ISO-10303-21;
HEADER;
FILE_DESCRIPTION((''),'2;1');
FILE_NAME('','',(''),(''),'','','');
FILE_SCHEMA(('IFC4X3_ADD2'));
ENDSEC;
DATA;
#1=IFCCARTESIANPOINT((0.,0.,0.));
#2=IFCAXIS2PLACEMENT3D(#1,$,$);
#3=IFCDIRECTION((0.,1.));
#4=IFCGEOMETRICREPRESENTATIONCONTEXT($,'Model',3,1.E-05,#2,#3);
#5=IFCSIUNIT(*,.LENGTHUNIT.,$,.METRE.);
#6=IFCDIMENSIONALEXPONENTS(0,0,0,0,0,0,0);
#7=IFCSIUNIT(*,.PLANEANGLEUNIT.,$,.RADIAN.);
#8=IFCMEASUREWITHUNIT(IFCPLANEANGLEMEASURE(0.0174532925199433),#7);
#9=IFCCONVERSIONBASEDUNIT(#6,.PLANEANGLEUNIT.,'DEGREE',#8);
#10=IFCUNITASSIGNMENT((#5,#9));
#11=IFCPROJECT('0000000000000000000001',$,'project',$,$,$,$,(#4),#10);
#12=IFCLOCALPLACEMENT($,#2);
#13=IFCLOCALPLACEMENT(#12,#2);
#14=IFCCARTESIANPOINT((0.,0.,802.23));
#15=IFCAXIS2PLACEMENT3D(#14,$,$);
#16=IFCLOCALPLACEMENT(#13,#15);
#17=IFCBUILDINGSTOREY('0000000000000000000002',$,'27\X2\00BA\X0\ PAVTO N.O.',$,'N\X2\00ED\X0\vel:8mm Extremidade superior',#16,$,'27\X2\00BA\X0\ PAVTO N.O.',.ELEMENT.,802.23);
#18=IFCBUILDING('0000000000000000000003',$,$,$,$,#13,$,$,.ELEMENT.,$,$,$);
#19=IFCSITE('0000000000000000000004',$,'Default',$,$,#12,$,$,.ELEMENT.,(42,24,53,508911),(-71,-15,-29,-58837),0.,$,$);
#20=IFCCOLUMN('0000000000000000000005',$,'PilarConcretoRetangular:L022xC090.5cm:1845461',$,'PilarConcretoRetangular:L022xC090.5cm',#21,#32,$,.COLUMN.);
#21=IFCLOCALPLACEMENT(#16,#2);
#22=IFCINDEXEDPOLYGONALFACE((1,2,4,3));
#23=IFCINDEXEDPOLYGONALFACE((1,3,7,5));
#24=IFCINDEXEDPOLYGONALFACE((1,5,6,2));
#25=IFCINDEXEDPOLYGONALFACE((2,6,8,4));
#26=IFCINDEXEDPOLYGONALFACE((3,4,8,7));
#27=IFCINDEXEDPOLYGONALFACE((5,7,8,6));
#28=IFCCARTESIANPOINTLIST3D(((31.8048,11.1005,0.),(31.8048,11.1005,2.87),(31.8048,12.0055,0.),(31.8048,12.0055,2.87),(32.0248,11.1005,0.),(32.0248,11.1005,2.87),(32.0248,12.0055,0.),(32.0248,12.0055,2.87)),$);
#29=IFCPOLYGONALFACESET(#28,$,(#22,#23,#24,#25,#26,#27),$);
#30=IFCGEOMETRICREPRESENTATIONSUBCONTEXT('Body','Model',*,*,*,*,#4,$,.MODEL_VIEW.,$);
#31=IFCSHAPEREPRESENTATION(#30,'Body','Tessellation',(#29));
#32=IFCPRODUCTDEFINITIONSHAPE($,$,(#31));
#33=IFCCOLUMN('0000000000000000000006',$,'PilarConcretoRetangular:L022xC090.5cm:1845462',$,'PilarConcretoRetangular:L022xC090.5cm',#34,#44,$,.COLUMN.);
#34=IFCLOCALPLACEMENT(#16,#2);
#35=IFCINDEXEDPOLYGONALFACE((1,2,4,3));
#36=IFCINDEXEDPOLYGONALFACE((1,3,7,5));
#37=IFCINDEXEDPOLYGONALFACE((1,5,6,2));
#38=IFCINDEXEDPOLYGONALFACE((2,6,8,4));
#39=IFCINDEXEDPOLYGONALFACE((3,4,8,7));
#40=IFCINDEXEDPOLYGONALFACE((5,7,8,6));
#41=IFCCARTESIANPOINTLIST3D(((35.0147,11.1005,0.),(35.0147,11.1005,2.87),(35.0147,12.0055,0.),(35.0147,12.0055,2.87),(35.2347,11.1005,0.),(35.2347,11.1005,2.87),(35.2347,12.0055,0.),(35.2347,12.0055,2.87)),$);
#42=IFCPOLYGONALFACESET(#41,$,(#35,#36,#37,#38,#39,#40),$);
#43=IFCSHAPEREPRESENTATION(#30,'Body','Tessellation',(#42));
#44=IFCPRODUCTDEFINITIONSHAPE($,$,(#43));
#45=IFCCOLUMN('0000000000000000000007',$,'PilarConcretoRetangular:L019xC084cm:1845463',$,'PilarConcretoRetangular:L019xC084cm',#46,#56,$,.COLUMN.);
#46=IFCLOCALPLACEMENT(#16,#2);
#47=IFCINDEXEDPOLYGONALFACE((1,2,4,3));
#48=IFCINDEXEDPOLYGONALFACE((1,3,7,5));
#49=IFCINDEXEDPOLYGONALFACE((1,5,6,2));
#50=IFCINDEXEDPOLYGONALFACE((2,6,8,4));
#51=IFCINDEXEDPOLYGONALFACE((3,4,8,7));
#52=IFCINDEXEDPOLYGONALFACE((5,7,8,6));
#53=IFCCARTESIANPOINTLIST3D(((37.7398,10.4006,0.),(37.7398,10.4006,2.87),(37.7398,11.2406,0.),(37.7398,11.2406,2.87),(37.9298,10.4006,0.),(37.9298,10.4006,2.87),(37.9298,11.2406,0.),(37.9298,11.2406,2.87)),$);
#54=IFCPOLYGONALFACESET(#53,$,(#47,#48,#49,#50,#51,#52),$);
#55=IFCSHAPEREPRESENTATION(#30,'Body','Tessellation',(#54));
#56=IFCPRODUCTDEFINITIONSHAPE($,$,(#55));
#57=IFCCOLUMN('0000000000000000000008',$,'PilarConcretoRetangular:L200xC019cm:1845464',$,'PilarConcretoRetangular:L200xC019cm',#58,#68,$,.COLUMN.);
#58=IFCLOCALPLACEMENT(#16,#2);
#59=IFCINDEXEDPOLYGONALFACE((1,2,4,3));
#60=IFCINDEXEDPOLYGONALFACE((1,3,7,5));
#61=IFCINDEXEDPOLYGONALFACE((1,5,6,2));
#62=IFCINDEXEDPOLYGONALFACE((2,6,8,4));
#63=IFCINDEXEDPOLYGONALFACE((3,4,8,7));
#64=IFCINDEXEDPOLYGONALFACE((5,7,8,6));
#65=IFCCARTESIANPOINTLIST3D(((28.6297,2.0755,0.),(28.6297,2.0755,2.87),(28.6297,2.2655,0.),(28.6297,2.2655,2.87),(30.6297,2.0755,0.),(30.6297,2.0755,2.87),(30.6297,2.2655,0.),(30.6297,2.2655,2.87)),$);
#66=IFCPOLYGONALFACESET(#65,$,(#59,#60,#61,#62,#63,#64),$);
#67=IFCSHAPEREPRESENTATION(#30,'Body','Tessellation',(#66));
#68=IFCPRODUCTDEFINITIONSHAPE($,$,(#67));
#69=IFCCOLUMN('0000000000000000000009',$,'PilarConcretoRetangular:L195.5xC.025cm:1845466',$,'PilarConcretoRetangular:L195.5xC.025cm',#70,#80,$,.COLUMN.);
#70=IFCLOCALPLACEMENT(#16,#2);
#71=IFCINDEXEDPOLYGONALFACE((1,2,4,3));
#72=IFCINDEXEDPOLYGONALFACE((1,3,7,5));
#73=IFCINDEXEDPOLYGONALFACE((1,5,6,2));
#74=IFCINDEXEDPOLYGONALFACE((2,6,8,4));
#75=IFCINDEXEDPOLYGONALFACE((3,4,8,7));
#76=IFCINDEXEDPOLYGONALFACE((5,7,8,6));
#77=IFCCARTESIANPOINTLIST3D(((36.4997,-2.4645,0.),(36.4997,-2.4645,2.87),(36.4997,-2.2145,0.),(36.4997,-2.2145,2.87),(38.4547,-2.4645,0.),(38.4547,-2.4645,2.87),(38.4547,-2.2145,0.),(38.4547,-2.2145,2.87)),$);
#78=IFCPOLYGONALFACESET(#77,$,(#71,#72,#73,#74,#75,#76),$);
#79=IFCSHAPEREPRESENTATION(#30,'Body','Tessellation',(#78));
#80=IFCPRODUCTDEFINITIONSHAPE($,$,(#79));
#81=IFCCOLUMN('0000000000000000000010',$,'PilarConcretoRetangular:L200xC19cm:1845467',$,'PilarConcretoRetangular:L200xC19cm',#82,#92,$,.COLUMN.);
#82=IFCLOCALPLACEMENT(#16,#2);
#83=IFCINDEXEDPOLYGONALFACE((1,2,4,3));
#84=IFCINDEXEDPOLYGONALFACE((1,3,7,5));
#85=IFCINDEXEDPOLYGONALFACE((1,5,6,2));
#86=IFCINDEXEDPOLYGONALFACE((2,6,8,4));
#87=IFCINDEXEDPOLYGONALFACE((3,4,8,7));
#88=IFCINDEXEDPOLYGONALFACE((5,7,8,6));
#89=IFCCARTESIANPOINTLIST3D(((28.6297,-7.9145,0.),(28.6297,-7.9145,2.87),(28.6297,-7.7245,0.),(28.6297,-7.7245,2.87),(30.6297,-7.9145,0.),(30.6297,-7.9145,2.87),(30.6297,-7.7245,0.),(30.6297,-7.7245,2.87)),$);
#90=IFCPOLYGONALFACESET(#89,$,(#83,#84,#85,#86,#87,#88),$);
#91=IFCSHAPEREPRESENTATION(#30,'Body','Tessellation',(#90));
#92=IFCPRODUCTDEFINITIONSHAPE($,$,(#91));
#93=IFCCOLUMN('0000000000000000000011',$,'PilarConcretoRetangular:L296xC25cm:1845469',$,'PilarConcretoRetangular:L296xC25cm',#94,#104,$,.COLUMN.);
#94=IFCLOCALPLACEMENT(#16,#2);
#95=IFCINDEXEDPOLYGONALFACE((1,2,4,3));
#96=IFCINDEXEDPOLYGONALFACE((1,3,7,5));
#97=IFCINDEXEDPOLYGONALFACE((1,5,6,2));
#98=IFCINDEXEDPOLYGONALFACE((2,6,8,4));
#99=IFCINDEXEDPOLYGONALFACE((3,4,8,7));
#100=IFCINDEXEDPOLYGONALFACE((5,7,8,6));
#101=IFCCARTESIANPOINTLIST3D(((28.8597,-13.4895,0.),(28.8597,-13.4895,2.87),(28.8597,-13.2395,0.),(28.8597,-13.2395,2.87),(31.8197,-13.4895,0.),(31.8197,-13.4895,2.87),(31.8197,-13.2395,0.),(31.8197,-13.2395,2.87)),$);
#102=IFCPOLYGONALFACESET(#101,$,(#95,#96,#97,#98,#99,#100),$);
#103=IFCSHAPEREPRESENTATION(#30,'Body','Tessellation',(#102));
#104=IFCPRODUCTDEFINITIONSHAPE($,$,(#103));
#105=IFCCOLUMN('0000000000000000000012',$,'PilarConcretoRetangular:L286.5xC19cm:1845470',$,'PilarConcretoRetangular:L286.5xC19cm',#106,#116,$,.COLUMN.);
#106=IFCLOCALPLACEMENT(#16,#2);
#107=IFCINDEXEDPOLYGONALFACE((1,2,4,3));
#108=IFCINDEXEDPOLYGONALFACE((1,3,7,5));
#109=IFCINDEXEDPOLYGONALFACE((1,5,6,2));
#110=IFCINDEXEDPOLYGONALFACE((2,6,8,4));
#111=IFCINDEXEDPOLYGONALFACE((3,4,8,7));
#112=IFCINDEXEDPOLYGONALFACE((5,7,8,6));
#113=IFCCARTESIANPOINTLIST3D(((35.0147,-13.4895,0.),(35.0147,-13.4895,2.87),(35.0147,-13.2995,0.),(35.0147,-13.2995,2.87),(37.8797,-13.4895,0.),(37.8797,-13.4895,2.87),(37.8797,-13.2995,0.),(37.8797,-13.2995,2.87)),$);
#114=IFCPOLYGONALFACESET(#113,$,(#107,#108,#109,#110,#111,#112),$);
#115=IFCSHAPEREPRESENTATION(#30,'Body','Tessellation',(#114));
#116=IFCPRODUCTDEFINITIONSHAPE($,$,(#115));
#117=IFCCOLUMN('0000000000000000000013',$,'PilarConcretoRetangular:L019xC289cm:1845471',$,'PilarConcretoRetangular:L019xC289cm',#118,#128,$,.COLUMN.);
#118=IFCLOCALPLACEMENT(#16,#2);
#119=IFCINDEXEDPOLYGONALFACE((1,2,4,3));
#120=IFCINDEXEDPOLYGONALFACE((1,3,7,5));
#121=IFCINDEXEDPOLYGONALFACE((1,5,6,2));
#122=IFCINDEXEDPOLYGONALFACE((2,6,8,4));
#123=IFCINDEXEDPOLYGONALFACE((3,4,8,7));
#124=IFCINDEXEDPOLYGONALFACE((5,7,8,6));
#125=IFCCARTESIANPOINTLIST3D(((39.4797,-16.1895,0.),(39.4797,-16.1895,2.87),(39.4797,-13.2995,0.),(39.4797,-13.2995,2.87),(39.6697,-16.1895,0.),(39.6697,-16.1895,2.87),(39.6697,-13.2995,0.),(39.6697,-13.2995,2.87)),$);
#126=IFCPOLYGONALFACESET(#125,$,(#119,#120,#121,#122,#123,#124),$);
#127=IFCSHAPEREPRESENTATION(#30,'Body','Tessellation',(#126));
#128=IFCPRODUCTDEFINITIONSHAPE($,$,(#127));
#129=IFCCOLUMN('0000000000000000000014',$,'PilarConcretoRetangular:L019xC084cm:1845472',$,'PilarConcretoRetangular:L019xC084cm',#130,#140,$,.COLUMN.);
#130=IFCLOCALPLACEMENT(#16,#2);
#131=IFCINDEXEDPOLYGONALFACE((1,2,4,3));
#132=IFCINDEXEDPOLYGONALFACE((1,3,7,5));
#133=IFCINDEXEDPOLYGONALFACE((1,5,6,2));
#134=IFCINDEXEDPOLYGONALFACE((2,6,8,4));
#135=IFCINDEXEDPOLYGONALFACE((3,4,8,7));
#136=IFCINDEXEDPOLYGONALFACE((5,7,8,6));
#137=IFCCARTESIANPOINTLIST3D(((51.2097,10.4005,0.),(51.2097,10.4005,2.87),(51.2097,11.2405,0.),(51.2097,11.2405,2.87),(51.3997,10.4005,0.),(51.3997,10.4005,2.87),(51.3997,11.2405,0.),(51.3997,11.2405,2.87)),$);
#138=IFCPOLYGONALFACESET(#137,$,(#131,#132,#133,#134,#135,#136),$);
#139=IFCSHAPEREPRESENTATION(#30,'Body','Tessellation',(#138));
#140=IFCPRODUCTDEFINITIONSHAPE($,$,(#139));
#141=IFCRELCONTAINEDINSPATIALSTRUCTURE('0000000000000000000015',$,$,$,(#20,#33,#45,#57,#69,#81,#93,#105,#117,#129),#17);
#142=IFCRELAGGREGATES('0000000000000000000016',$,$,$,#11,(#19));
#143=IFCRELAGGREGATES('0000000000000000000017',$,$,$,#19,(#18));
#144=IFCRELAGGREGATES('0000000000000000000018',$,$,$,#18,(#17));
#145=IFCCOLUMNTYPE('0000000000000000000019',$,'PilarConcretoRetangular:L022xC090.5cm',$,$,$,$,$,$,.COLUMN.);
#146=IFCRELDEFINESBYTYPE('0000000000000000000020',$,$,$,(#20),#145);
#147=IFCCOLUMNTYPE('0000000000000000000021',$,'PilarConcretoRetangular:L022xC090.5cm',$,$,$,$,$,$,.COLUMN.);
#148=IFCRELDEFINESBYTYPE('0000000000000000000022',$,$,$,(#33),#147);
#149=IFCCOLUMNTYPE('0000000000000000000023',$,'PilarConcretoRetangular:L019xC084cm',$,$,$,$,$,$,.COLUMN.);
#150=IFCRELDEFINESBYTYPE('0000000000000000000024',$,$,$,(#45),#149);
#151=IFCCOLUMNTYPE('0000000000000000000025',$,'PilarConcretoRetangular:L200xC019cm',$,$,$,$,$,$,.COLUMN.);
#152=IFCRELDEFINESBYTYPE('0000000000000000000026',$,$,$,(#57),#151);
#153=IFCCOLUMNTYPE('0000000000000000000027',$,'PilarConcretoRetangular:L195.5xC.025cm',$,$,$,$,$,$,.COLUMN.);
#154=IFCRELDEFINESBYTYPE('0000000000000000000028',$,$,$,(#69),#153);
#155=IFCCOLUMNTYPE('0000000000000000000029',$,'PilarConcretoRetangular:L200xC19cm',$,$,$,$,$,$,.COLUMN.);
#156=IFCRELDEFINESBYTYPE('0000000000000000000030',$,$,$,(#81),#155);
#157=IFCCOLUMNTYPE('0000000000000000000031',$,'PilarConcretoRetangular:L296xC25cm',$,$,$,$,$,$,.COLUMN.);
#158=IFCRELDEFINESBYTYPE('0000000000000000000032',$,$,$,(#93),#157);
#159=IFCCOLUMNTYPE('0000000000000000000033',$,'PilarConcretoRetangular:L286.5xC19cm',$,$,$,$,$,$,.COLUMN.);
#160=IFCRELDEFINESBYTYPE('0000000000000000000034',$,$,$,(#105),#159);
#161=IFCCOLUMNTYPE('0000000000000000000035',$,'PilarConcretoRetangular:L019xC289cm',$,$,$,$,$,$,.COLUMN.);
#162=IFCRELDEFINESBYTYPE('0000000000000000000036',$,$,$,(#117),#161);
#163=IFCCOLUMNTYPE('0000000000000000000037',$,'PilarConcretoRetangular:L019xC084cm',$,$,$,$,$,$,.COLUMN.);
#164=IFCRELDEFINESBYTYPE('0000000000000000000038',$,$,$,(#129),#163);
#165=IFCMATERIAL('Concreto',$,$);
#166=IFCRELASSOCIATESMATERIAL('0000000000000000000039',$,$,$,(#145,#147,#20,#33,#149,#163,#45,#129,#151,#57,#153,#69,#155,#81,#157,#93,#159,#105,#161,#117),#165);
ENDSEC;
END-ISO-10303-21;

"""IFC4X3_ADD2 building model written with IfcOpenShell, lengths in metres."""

from ifc_helpers import new_model, entity, si_unit, converted_unit, direction, frame, frame_2d, origin, origin_2d_with_axis, place, context, subcontext, project, spatial, rectangle, extrude, source, transform, mapped, material, material_profile, profile_set, profile_usage, type_object, type_shapes, element, save


model = new_model("IFC4X3_ADD2")

# Units and contexts
model_context = context("Model", 3, precision=1e-05, world=origin(), true_north=direction((0.0, 1.0)))
body_context = subcontext(model_context, "Body", "Model", "MODEL_VIEW")
ifc_project = project(units=[si_unit("LENGTHUNIT", "METRE"), converted_unit("PLANEANGLEUNIT", "DEGREE", entity("IfcPlaneAngleMeasure", 0.0174532925199433), si_unit("PLANEANGLEUNIT", "RADIAN"), dimensions=[0, 0, 0, 0, 0, 0, 0])], contexts=[model_context])

# Site, building, storey
site_placement = place(None, origin())
site = spatial("IfcSite", under=ifc_project, at=site_placement, Name="Default", CompositionType="ELEMENT", RefLatitude=(42, 24, 53, 508911), RefLongitude=(-71, -15, -29, -58837), RefElevation=0.0)
building_placement = place(site_placement, origin())
building = spatial("IfcBuilding", under=site, at=building_placement, CompositionType="ELEMENT")
storey_placement = place(building_placement, frame((0.0, 0.0, 802.23)))
storey = spatial("IfcBuildingStorey", under=building, at=storey_placement, Name="27º PAVTO N.O.", ObjectType="Nível:8mm Extremidade superior", LongName="27º PAVTO N.O.", CompositionType="ELEMENT", Elevation=802.23)

# Columns
ifc_material = material(Name="Concreto")
ifc_material_profile_1 = material_profile(ifc_material, rectangle(XDim=0.22, YDim=0.905, at=frame_2d((0.0, 0.0), x_axis=(1.0, 0.0))), Name="L022xC090.5cm")
ifc_profile_set_1 = profile_set([ifc_material_profile_1], Name="L022xC090.5cm")
ifc_profile_usage_1 = profile_usage(ifc_profile_set_1)
column_type_1 = type_object("IfcColumnType", Name="PilarConcretoRetangular:L022xC090.5cm", PredefinedType="COLUMN", material=ifc_profile_set_1)
shared_shape_1 = source(origin(), body_context, "Body", "SweptSolid", [
    extrude(rectangle(XDim=0.22, YDim=0.905, at=frame_2d((0.0, 0.0), x_axis=(1.0, 0.0))), frame((31.9148, 11.553, 802.23), z_axis=(0.0, 0.0, 1.0), x_axis=(-1.0, 0.0, 0.0)), (0.0, 0.0, 1.0), 2.87),
])
type_shapes(column_type_1, [shared_shape_1])
column_1_placement = place(storey_placement, frame((0.0, 0.0, -802.23)))
element("IfcColumn", 1, at=column_1_placement, inside=storey, type_object=column_type_1, material=ifc_profile_usage_1, Name="PilarConcretoRetangular:L022xC090.5cm:1845461", ObjectType="PilarConcretoRetangular:L022xC090.5cm", PredefinedType="COLUMN", context=body_context, shape_type="MappedRepresentation", body=[
    mapped(shared_shape_1, transform((0.0, 0.0, 0.0), scale=1.0)),
])
column_type_2 = type_object("IfcColumnType", Name="PilarConcretoRetangular:L022xC090.5cm", PredefinedType="COLUMN", material=ifc_profile_set_1)
shared_shape_2 = source(origin(), body_context, "Body", "SweptSolid", [
    extrude(rectangle(XDim=0.22, YDim=0.905, at=frame_2d((0.0, 0.0), x_axis=(1.0, 0.0))), frame((35.1247, 11.553, 802.23), z_axis=(0.0, 0.0, 1.0), x_axis=(-1.0, 0.0, 0.0)), (0.0, 0.0, 1.0), 2.87),
])
type_shapes(column_type_2, [shared_shape_2])
column_2_placement = place(storey_placement, frame((0.0, 0.0, -802.23)))
element("IfcColumn", 2, at=column_2_placement, inside=storey, type_object=column_type_2, material=ifc_profile_usage_1, Name="PilarConcretoRetangular:L022xC090.5cm:1845462", ObjectType="PilarConcretoRetangular:L022xC090.5cm", PredefinedType="COLUMN", context=body_context, shape_type="MappedRepresentation", body=[
    mapped(shared_shape_2, transform((0.0, 0.0, 0.0), scale=1.0)),
])
ifc_material_profile_2 = material_profile(ifc_material, rectangle(XDim=0.19, YDim=0.84, at=frame_2d((0.0, 0.0), x_axis=(1.0, 0.0))), Name="L019xC084cm")
ifc_profile_set_2 = profile_set([ifc_material_profile_2], Name="L019xC084cm")
ifc_profile_usage_2 = profile_usage(ifc_profile_set_2)
column_type_3 = type_object("IfcColumnType", Name="PilarConcretoRetangular:L019xC084cm", PredefinedType="COLUMN", material=ifc_profile_set_2)
shared_shape_3 = source(origin(), body_context, "Body", "SweptSolid", [
    extrude(rectangle(XDim=0.19, YDim=0.84, at=origin_2d_with_axis()), frame((37.8348, 10.8206, 802.23), z_axis=(0.0, 0.0, 1.0), x_axis=(-1.0, 0.0, 0.0)), (0.0, 0.0, 1.0), 2.87),
])
type_shapes(column_type_3, [shared_shape_3])
column_3_placement = place(storey_placement, frame((0.0, 0.0, -802.23)))
element("IfcColumn", 3, at=column_3_placement, inside=storey, type_object=column_type_3, material=ifc_profile_usage_2, Name="PilarConcretoRetangular:L019xC084cm:1845463", ObjectType="PilarConcretoRetangular:L019xC084cm", PredefinedType="COLUMN", context=body_context, shape_type="MappedRepresentation", body=[
    mapped(shared_shape_3, transform((0.0, 0.0, 0.0), scale=1.0)),
])
ifc_material_profile_3 = material_profile(ifc_material, rectangle(XDim=2.0, YDim=0.19, at=frame_2d((0.0, 0.0), x_axis=(1.0, 0.0))), Name="L200xC019cm")
ifc_profile_set_3 = profile_set([ifc_material_profile_3], Name="L200xC019cm")
ifc_profile_usage_3 = profile_usage(ifc_profile_set_3)
column_type_4 = type_object("IfcColumnType", Name="PilarConcretoRetangular:L200xC019cm", PredefinedType="COLUMN", material=ifc_profile_set_3)
shared_shape_4 = source(origin(), body_context, "Body", "SweptSolid", [
    extrude(rectangle(XDim=2.0, YDim=0.19, at=frame_2d((0.0, 0.0), x_axis=(1.0, 0.0))), frame((29.6297, 2.1705, 802.23)), (0.0, 0.0, 1.0), 2.87),
])
type_shapes(column_type_4, [shared_shape_4])
column_4_placement = place(storey_placement, frame((0.0, 0.0, -802.23)))
element("IfcColumn", 4, at=column_4_placement, inside=storey, type_object=column_type_4, material=ifc_profile_usage_3, Name="PilarConcretoRetangular:L200xC019cm:1845464", ObjectType="PilarConcretoRetangular:L200xC019cm", PredefinedType="COLUMN", context=body_context, shape_type="MappedRepresentation", body=[
    mapped(shared_shape_4, transform((0.0, 0.0, 0.0), scale=1.0)),
])
ifc_material_profile_4 = material_profile(ifc_material, rectangle(XDim=1.955, YDim=0.25, at=frame_2d((0.0, 0.0), x_axis=(1.0, 0.0))), Name="L195.5xC.025cm")
ifc_profile_set_4 = profile_set([ifc_material_profile_4], Name="L195.5xC.025cm")
ifc_profile_usage_4 = profile_usage(ifc_profile_set_4)
column_type_5 = type_object("IfcColumnType", Name="PilarConcretoRetangular:L195.5xC.025cm", PredefinedType="COLUMN", material=ifc_profile_set_4)
shared_shape_5 = source(origin(), body_context, "Body", "SweptSolid", [
    extrude(rectangle(XDim=1.955, YDim=0.25, at=frame_2d((0.0, 0.0), x_axis=(1.0, 0.0))), frame((37.4772, -2.3395, 802.23)), (0.0, 0.0, 1.0), 2.87),
])
type_shapes(column_type_5, [shared_shape_5])
column_5_placement = place(storey_placement, frame((0.0, 0.0, -802.23)))
element("IfcColumn", 5, at=column_5_placement, inside=storey, type_object=column_type_5, material=ifc_profile_usage_4, Name="PilarConcretoRetangular:L195.5xC.025cm:1845466", ObjectType="PilarConcretoRetangular:L195.5xC.025cm", PredefinedType="COLUMN", context=body_context, shape_type="MappedRepresentation", body=[
    mapped(shared_shape_5, transform((0.0, 0.0, 0.0), scale=1.0)),
])
ifc_material_profile_5 = material_profile(ifc_material, rectangle(XDim=2.0, YDim=0.19, at=frame_2d((0.0, 0.0), x_axis=(1.0, 0.0))), Name="L200xC19cm")
ifc_profile_set_5 = profile_set([ifc_material_profile_5], Name="L200xC19cm")
ifc_profile_usage_5 = profile_usage(ifc_profile_set_5)
column_type_6 = type_object("IfcColumnType", Name="PilarConcretoRetangular:L200xC19cm", PredefinedType="COLUMN", material=ifc_profile_set_5)
shared_shape_6 = source(origin(), body_context, "Body", "SweptSolid", [
    extrude(rectangle(XDim=2.0, YDim=0.19, at=frame_2d((0.0, 0.0), x_axis=(1.0, 0.0))), frame((29.6297, -7.8195, 802.23)), (0.0, 0.0, 1.0), 2.87),
])
type_shapes(column_type_6, [shared_shape_6])
column_6_placement = place(storey_placement, frame((0.0, 0.0, -802.23)))
element("IfcColumn", 6, at=column_6_placement, inside=storey, type_object=column_type_6, material=ifc_profile_usage_5, Name="PilarConcretoRetangular:L200xC19cm:1845467", ObjectType="PilarConcretoRetangular:L200xC19cm", PredefinedType="COLUMN", context=body_context, shape_type="MappedRepresentation", body=[
    mapped(shared_shape_6, transform((0.0, 0.0, 0.0), scale=1.0)),
])
ifc_material_profile_6 = material_profile(ifc_material, rectangle(XDim=2.96, YDim=0.25, at=frame_2d((0.0, 0.0), x_axis=(1.0, 0.0))), Name="L296xC25cm")
ifc_profile_set_6 = profile_set([ifc_material_profile_6], Name="L296xC25cm")
ifc_profile_usage_6 = profile_usage(ifc_profile_set_6)
column_type_7 = type_object("IfcColumnType", Name="PilarConcretoRetangular:L296xC25cm", PredefinedType="COLUMN", material=ifc_profile_set_6)
shared_shape_7 = source(origin(), body_context, "Body", "SweptSolid", [
    extrude(rectangle(XDim=2.96, YDim=0.25, at=frame_2d((0.0, 0.0), x_axis=(1.0, 0.0))), frame((30.3397, -13.3645, 802.23)), (0.0, 0.0, 1.0), 2.87),
])
type_shapes(column_type_7, [shared_shape_7])
column_7_placement = place(storey_placement, frame((0.0, 0.0, -802.23)))
element("IfcColumn", 7, at=column_7_placement, inside=storey, type_object=column_type_7, material=ifc_profile_usage_6, Name="PilarConcretoRetangular:L296xC25cm:1845469", ObjectType="PilarConcretoRetangular:L296xC25cm", PredefinedType="COLUMN", context=body_context, shape_type="MappedRepresentation", body=[
    mapped(shared_shape_7, transform((0.0, 0.0, 0.0), scale=1.0)),
])
ifc_material_profile_7 = material_profile(ifc_material, rectangle(XDim=2.865, YDim=0.19, at=frame_2d((0.0, 0.0), x_axis=(1.0, 0.0))), Name="L286.5xC19cm")
ifc_profile_set_7 = profile_set([ifc_material_profile_7], Name="L286.5xC19cm")
ifc_profile_usage_7 = profile_usage(ifc_profile_set_7)
column_type_8 = type_object("IfcColumnType", Name="PilarConcretoRetangular:L286.5xC19cm", PredefinedType="COLUMN", material=ifc_profile_set_7)
shared_shape_8 = source(origin(), body_context, "Body", "SweptSolid", [
    extrude(rectangle(XDim=2.865, YDim=0.19, at=frame_2d((0.0, 0.0), x_axis=(1.0, 0.0))), frame((36.4472, -13.3945, 802.23)), (0.0, 0.0, 1.0), 2.87),
])
type_shapes(column_type_8, [shared_shape_8])
column_8_placement = place(storey_placement, frame((0.0, 0.0, -802.23)))
element("IfcColumn", 8, at=column_8_placement, inside=storey, type_object=column_type_8, material=ifc_profile_usage_7, Name="PilarConcretoRetangular:L286.5xC19cm:1845470", ObjectType="PilarConcretoRetangular:L286.5xC19cm", PredefinedType="COLUMN", context=body_context, shape_type="MappedRepresentation", body=[
    mapped(shared_shape_8, transform((0.0, 0.0, 0.0), scale=1.0)),
])
ifc_material_profile_8 = material_profile(ifc_material, rectangle(XDim=0.19, YDim=2.89, at=frame_2d((0.0, 0.0), x_axis=(1.0, 0.0))), Name="L019xC289cm")
ifc_profile_set_8 = profile_set([ifc_material_profile_8], Name="L019xC289cm")
ifc_profile_usage_8 = profile_usage(ifc_profile_set_8)
column_type_9 = type_object("IfcColumnType", Name="PilarConcretoRetangular:L019xC289cm", PredefinedType="COLUMN", material=ifc_profile_set_8)
shared_shape_9 = source(origin(), body_context, "Body", "SweptSolid", [
    extrude(rectangle(XDim=0.19, YDim=2.89, at=frame_2d((0.0, 0.0), x_axis=(1.0, 0.0))), frame((39.5747, -14.7445, 802.23), z_axis=(0.0, 0.0, 1.0), x_axis=(-1.0, 0.0, 0.0)), (0.0, 0.0, 1.0), 2.87),
])
type_shapes(column_type_9, [shared_shape_9])
column_9_placement = place(storey_placement, frame((0.0, 0.0, -802.23)))
element("IfcColumn", 9, at=column_9_placement, inside=storey, type_object=column_type_9, material=ifc_profile_usage_8, Name="PilarConcretoRetangular:L019xC289cm:1845471", ObjectType="PilarConcretoRetangular:L019xC289cm", PredefinedType="COLUMN", context=body_context, shape_type="MappedRepresentation", body=[
    mapped(shared_shape_9, transform((0.0, 0.0, 0.0), scale=1.0)),
])
column_type_10 = type_object("IfcColumnType", Name="PilarConcretoRetangular:L019xC084cm", PredefinedType="COLUMN", material=ifc_profile_set_2)
shared_shape_10 = source(origin(), body_context, "Body", "SweptSolid", [
    extrude(rectangle(XDim=0.19, YDim=0.84, at=frame_2d((0.0, 0.0), x_axis=(1.0, 0.0))), frame((51.3047, 10.8205, 802.23)), (0.0, 0.0, 1.0), 2.87),
])
type_shapes(column_type_10, [shared_shape_10])
column_10_placement = place(storey_placement, frame((0.0, 0.0, -802.23)))
element("IfcColumn", 10, at=column_10_placement, inside=storey, type_object=column_type_10, material=ifc_profile_usage_2, Name="PilarConcretoRetangular:L019xC084cm:1845472", ObjectType="PilarConcretoRetangular:L019xC084cm", PredefinedType="COLUMN", context=body_context, shape_type="MappedRepresentation", body=[
    mapped(shared_shape_10, transform((0.0, 0.0, 0.0), scale=1.0)),
])

save(model, "model.ifc")
